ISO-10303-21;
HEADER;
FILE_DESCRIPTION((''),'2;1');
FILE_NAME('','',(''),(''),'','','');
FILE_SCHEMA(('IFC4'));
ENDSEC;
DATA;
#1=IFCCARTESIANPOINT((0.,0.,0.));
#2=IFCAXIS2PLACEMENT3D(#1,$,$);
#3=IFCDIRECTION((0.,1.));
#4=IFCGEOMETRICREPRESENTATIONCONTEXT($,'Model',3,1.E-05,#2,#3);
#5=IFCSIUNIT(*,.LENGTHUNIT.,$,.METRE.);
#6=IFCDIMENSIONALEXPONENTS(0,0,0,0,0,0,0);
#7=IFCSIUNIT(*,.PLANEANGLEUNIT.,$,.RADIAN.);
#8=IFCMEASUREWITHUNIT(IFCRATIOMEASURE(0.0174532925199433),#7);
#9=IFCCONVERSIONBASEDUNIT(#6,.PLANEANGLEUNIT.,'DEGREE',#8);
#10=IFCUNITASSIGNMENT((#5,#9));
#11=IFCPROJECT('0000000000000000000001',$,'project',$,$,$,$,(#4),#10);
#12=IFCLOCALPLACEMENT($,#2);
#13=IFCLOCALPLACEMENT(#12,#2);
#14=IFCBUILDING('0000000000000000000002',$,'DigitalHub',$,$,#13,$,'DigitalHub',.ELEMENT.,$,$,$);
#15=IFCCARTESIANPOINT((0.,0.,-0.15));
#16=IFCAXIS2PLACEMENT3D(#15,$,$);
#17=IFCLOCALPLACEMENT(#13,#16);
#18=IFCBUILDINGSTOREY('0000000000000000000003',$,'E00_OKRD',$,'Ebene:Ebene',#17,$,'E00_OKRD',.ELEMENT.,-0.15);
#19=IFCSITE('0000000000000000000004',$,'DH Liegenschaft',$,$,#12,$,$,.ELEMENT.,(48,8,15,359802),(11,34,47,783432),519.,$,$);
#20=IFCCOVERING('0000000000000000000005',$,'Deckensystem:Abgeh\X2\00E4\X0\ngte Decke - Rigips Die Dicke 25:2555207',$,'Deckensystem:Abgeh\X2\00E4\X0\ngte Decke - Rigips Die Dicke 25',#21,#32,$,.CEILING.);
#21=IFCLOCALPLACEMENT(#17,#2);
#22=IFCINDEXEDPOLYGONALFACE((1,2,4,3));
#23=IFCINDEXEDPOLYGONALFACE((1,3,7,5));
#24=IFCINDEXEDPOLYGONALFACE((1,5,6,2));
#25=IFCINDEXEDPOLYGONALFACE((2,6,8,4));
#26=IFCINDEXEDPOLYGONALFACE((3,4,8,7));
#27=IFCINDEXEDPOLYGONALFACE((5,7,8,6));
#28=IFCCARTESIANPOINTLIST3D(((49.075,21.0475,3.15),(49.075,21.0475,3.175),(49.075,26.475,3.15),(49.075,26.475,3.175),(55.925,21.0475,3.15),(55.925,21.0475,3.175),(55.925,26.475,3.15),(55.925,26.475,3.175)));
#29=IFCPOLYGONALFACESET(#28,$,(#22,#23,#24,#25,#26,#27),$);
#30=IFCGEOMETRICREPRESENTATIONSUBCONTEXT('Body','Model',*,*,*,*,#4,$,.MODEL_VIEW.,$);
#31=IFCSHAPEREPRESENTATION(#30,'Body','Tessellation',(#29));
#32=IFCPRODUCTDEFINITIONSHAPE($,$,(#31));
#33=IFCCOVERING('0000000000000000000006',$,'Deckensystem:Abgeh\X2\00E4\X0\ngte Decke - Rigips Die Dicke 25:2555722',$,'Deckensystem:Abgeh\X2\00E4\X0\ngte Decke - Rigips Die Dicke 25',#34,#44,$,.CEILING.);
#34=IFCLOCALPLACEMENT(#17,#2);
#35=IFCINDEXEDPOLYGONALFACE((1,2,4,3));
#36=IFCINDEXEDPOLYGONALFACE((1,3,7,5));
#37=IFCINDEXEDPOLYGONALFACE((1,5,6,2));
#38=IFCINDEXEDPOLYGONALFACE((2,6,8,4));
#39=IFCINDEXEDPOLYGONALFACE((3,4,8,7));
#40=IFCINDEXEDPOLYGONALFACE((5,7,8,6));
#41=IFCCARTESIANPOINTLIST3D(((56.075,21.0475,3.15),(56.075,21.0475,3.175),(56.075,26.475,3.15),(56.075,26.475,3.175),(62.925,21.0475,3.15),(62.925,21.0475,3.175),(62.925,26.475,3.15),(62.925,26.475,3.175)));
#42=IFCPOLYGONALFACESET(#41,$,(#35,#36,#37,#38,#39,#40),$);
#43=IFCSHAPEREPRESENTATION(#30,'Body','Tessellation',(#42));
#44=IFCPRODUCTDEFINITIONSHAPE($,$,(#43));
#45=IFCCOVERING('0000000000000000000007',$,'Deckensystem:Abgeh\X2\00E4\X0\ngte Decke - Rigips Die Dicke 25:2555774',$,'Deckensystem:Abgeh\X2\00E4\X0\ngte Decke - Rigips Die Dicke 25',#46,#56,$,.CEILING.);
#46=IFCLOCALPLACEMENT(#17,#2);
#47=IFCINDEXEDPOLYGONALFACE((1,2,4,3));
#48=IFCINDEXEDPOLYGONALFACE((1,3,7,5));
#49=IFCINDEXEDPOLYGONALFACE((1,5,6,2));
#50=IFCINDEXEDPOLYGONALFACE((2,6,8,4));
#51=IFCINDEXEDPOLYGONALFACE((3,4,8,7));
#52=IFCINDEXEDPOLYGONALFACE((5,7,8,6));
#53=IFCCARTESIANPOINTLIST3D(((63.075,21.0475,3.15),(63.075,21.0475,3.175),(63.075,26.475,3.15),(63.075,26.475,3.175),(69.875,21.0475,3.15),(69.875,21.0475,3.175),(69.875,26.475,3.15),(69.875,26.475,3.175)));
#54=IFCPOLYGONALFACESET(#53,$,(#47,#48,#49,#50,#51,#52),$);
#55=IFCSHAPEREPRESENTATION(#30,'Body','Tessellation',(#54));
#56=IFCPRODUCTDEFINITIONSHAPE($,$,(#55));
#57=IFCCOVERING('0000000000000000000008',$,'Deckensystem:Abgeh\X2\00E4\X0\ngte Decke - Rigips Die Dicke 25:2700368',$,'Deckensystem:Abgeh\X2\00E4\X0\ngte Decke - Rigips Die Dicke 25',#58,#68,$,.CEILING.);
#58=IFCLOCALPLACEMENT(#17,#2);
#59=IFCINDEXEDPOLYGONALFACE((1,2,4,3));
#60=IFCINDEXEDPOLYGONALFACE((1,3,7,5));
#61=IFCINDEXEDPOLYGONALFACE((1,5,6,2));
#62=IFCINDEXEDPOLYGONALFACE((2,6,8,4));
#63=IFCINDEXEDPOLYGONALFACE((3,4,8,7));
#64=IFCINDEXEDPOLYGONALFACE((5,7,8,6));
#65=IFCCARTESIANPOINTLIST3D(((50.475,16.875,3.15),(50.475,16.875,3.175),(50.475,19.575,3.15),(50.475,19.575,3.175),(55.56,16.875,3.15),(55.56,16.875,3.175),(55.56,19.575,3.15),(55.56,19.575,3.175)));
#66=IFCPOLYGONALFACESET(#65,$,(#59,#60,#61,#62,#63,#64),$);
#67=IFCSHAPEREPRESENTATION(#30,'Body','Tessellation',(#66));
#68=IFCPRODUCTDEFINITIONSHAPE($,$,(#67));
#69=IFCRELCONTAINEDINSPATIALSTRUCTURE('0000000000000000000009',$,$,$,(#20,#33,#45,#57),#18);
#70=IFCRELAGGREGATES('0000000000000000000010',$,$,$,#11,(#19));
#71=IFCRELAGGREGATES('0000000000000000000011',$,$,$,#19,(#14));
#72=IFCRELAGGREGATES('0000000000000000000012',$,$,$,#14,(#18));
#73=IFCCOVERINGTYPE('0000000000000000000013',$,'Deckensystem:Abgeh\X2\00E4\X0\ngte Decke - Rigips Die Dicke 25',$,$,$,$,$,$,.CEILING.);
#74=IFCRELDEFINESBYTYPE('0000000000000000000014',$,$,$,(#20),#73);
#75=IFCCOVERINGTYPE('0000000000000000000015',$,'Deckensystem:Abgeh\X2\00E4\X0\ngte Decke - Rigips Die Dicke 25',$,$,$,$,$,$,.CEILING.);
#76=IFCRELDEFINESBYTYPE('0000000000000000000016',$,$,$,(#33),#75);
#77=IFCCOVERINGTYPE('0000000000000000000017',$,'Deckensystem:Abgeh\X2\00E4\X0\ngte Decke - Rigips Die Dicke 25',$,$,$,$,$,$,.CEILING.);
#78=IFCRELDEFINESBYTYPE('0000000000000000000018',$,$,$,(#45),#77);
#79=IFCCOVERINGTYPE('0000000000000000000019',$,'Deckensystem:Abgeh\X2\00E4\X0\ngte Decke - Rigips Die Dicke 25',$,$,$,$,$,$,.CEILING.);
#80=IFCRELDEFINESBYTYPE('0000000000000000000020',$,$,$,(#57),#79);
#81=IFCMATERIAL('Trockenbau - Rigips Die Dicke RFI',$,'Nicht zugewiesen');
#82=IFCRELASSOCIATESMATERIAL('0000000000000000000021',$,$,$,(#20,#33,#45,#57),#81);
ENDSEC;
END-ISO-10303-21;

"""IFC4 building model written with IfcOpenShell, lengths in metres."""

from ifc_helpers import new_model, entity, si_unit, converted_unit, direction, frame, origin, place, context, subcontext, project, spatial, indexed_curve, outline, extrude, material, type_object, element, save


model = new_model("IFC4")

# Units and contexts
model_context = context("Model", 3, precision=1e-05, world=origin(), true_north=direction((0.0, 1.0)))
body_context = subcontext(model_context, "Body", "Model", "MODEL_VIEW")
ifc_project = project(units=[si_unit("LENGTHUNIT", "METRE"), converted_unit("PLANEANGLEUNIT", "DEGREE", entity("IfcRatioMeasure", 0.0174532925199433), si_unit("PLANEANGLEUNIT", "RADIAN"), dimensions=[0, 0, 0, 0, 0, 0, 0])], contexts=[model_context])

# Site, building, storey
site_placement = place(None, frame((0.0, 0.0, 0.0)))
site = spatial("IfcSite", under=ifc_project, at=site_placement, Name="DH Liegenschaft", CompositionType="ELEMENT", RefLatitude=(48, 8, 15, 359802), RefLongitude=(11, 34, 47, 783432), RefElevation=519.0)
building_placement = place(site_placement, origin())
building = spatial("IfcBuilding", under=site, at=building_placement, Name="DigitalHub", LongName="DigitalHub", CompositionType="ELEMENT")
storey_placement = place(building_placement, frame((0.0, 0.0, -0.15)))
storey = spatial("IfcBuildingStorey", under=building, at=storey_placement, Name="E00_OKRD", ObjectType="Ebene:Ebene", LongName="E00_OKRD", CompositionType="ELEMENT", Elevation=-0.15)

# Coverings
ifc_material_1 = material(Name="Trockenbau - Rigips Die Dicke RFI", Category="Nicht zugewiesen")
covering_type_1 = type_object("IfcCoveringType", Name="Deckensystem:Abgehängte Decke - Rigips Die Dicke 25", PredefinedType="CEILING")
covering_1_placement = place(storey_placement, frame((49.075, 21.0475, 3.15)))
element("IfcCovering", 1, at=covering_1_placement, inside=storey, type_object=covering_type_1, material=ifc_material_1, Name="Deckensystem:Abgehängte Decke - Rigips Die Dicke 25:2555207", ObjectType="Deckensystem:Abgehängte Decke - Rigips Die Dicke 25", PredefinedType="CEILING", context=body_context, shape_type="SweptSolid", body=[
    extrude(outline(indexed_curve([(-3.425, -2.7137), (3.425, -2.7137), (3.425, 2.7137), (-3.425, 2.7137), (-3.425, -2.7137)], self_intersect=False)), frame((3.425, 2.7137, 0.0)), (0.0, 0.0, 1.0), 0.025),
])
covering_type_2 = type_object("IfcCoveringType", Name="Deckensystem:Abgehängte Decke - Rigips Die Dicke 25", PredefinedType="CEILING")
covering_2_placement = place(storey_placement, frame((56.075, 21.0475, 3.15)))
element("IfcCovering", 2, at=covering_2_placement, inside=storey, type_object=covering_type_2, material=ifc_material_1, Name="Deckensystem:Abgehängte Decke - Rigips Die Dicke 25:2555722", ObjectType="Deckensystem:Abgehängte Decke - Rigips Die Dicke 25", PredefinedType="CEILING", context=body_context, shape_type="SweptSolid", body=[
    extrude(outline(indexed_curve([(-3.425, -2.7137), (3.425, -2.7137), (3.425, 2.7137), (-3.425, 2.7137), (-3.425, -2.7137)], self_intersect=False)), frame((3.425, 2.7137, 0.0), z_axis=(0.0, 0.0, 1.0), x_axis=(-1.0, 0.0, 0.0)), (0.0, 0.0, 1.0), 0.025),
])
covering_type_3 = type_object("IfcCoveringType", Name="Deckensystem:Abgehängte Decke - Rigips Die Dicke 25", PredefinedType="CEILING")
covering_3_placement = place(storey_placement, frame((63.075, 21.0475, 3.15)))
element("IfcCovering", 3, at=covering_3_placement, inside=storey, type_object=covering_type_3, material=ifc_material_1, Name="Deckensystem:Abgehängte Decke - Rigips Die Dicke 25:2555774", ObjectType="Deckensystem:Abgehängte Decke - Rigips Die Dicke 25", PredefinedType="CEILING", context=body_context, shape_type="SweptSolid", body=[
    extrude(outline(indexed_curve([(-3.4, -2.7137), (3.4, -2.7137), (3.4, 2.7137), (-3.4, 2.7137), (-3.4, -2.7137)], self_intersect=False)), frame((3.4, 2.7137, 0.0), z_axis=(0.0, 0.0, 1.0), x_axis=(-1.0, 0.0, 0.0)), (0.0, 0.0, 1.0), 0.025),
])
covering_type_4 = type_object("IfcCoveringType", Name="Deckensystem:Abgehängte Decke - Rigips Die Dicke 25", PredefinedType="CEILING")
covering_4_placement = place(storey_placement, frame((50.475, 16.875, 3.15)))
element("IfcCovering", 4, at=covering_4_placement, inside=storey, type_object=covering_type_4, material=ifc_material_1, Name="Deckensystem:Abgehängte Decke - Rigips Die Dicke 25:2700368", ObjectType="Deckensystem:Abgehängte Decke - Rigips Die Dicke 25", PredefinedType="CEILING", context=body_context, shape_type="SweptSolid", body=[
    extrude(outline(indexed_curve([(-2.5425, -1.35), (2.5425, -1.35), (2.5425, 1.35), (-2.5425, 1.35), (-2.5425, -1.35)], self_intersect=False)), frame((2.5425, 1.35, 0.0), z_axis=(0.0, 0.0, 1.0), x_axis=(-1.0, 0.0, 0.0)), (0.0, 0.0, 1.0), 0.025),
])

save(model, "model.ifc")
